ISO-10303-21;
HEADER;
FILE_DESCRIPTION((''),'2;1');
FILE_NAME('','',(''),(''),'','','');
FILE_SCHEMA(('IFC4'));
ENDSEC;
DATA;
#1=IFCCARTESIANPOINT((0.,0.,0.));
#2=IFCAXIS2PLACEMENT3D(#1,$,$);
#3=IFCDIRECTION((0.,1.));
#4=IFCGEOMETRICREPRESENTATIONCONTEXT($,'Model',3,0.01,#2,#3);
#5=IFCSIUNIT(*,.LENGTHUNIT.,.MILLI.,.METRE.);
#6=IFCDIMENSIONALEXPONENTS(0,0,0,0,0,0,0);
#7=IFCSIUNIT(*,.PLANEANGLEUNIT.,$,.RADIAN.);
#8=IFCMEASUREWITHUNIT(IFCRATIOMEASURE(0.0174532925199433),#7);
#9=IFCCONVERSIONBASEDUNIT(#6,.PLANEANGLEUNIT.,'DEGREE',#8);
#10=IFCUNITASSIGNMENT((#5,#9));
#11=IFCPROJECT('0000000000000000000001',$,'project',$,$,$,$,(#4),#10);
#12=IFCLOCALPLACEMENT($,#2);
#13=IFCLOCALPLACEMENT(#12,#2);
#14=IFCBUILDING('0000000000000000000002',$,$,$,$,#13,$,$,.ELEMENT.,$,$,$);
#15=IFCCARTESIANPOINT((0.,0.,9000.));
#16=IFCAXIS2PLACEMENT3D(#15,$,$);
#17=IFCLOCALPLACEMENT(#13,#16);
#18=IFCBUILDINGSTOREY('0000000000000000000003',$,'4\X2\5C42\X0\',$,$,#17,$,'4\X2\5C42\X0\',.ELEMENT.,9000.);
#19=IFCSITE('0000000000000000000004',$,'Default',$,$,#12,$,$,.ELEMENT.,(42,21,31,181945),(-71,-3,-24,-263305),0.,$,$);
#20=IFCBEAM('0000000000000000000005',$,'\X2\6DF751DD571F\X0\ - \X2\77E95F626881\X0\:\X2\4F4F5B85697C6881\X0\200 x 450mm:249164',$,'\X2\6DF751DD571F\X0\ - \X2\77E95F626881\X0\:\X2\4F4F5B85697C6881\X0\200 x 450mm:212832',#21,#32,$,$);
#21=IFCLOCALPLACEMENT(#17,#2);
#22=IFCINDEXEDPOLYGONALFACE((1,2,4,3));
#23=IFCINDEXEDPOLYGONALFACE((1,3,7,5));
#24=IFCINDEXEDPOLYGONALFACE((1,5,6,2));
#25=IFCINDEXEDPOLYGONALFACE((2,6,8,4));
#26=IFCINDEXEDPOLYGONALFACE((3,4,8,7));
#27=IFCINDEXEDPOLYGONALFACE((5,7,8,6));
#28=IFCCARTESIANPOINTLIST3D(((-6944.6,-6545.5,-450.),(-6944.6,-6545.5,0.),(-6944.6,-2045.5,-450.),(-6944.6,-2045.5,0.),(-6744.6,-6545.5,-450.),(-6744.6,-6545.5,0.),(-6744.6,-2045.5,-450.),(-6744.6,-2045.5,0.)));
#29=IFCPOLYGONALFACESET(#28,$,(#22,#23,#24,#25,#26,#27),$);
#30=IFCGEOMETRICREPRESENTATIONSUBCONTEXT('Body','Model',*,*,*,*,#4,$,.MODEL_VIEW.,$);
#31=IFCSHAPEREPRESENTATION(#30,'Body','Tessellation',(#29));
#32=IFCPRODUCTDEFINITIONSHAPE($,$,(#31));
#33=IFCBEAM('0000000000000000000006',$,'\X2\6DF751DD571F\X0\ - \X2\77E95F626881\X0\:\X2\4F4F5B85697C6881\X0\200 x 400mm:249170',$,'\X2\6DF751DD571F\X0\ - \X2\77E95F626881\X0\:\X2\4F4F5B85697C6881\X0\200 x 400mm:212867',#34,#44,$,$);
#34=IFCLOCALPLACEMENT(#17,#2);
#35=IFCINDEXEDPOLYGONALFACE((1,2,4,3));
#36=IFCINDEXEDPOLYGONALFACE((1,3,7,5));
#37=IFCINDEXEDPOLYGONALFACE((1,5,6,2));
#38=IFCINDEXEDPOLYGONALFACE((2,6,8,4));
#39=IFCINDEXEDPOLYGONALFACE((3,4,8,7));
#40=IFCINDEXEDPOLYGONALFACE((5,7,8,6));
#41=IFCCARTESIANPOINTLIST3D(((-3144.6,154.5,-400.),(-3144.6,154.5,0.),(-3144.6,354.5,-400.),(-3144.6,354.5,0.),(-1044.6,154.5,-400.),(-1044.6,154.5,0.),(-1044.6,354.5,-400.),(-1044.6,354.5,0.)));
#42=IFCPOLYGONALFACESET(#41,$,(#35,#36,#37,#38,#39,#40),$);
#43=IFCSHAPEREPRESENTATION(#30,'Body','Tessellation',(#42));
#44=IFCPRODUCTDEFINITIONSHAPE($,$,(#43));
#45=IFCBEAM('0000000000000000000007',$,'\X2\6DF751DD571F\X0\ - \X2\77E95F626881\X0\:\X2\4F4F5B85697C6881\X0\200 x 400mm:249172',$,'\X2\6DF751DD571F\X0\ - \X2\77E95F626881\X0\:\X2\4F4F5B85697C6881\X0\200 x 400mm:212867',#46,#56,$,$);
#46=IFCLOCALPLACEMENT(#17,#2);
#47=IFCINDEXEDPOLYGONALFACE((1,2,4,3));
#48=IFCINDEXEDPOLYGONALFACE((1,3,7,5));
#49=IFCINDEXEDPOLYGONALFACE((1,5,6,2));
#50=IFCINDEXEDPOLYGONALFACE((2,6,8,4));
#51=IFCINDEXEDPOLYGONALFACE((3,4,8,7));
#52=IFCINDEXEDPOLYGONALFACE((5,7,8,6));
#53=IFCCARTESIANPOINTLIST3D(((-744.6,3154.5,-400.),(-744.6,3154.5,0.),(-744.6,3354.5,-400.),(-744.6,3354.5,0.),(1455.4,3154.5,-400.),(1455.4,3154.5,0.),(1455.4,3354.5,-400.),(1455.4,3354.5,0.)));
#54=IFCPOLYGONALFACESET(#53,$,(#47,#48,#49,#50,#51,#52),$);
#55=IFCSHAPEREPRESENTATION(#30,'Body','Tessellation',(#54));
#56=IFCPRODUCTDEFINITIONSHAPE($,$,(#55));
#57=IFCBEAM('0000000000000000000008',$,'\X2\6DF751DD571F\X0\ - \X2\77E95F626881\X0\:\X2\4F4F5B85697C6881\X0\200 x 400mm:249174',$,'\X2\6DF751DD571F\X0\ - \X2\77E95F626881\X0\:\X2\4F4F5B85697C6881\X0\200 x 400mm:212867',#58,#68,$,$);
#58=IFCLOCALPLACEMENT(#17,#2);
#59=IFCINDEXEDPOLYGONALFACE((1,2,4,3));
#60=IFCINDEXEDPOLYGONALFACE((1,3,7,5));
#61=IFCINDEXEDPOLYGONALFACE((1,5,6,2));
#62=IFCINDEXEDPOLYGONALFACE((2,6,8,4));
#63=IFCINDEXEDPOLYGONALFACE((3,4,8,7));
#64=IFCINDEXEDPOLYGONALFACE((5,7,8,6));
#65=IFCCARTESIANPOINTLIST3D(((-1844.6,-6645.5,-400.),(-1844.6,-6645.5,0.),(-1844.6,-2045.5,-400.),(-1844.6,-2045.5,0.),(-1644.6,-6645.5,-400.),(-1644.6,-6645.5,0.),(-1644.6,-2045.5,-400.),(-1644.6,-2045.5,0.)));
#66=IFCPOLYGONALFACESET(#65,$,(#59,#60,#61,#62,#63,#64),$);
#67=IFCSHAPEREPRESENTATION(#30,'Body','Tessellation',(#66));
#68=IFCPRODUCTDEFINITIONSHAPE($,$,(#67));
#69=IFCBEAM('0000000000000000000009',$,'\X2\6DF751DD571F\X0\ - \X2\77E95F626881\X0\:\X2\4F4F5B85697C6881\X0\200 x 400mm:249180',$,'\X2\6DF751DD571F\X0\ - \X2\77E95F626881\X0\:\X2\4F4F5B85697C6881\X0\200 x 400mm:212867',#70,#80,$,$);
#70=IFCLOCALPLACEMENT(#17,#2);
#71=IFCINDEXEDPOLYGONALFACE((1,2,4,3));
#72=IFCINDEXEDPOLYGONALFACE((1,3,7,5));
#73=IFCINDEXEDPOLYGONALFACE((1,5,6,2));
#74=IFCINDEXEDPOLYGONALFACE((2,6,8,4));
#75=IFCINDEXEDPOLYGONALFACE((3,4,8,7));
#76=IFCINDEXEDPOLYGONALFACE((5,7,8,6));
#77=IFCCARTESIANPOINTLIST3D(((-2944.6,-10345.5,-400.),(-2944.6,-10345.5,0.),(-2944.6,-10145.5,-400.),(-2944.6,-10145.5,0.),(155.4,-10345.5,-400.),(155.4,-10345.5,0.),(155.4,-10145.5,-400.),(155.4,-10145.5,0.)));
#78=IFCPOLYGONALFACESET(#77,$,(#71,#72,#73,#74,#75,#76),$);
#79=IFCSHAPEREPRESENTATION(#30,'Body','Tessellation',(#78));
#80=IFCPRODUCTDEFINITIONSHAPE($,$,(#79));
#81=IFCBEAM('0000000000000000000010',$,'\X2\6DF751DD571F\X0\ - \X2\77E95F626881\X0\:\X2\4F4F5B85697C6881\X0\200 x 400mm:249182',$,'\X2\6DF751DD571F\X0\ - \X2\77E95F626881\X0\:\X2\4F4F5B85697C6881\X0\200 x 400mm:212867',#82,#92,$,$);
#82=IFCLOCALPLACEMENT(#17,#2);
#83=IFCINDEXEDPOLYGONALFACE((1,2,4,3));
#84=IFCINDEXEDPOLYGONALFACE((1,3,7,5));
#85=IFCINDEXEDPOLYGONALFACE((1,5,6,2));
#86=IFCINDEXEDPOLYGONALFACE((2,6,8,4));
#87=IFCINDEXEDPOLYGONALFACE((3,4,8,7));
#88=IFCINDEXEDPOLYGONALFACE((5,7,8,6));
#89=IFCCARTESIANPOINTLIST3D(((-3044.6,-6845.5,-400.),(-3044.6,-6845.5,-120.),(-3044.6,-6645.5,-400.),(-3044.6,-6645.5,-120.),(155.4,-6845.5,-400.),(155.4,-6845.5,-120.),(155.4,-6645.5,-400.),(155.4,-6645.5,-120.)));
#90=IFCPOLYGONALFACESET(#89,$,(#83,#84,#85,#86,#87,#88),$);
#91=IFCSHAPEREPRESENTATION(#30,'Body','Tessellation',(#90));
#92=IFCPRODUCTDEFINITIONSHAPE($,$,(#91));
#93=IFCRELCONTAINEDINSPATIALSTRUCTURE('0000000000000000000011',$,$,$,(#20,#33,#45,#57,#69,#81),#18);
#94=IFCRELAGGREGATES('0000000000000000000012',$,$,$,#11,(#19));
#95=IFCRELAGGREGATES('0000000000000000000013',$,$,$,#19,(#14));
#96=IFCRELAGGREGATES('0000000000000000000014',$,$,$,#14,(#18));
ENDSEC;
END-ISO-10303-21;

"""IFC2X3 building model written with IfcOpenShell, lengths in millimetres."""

from ifc_helpers import new_model, entity, si_unit, converted_unit, direction, frame, frame_2d, origin, origin_2d_with_axis, place, context, subcontext, project, spatial, rectangle, extrude, element, save


model = new_model("IFC2X3")

# Units and contexts
model_context = context("Model", 3, precision=0.01, world=origin(), true_north=direction((0.0, 1.0)))
body_context = subcontext(model_context, "Body", "Model", "MODEL_VIEW")
ifc_project = project(units=[si_unit("LENGTHUNIT", "METRE", prefix="MILLI"), converted_unit("PLANEANGLEUNIT", "DEGREE", entity("IfcRatioMeasure", 0.0174532925199433), si_unit("PLANEANGLEUNIT", "RADIAN"), dimensions=[0, 0, 0, 0, 0, 0, 0])], contexts=[model_context])

# Site, building, storey
site_placement = place(None, origin())
site = spatial("IfcSite", under=ifc_project, at=site_placement, Name="Default", CompositionType="ELEMENT", RefLatitude=(42, 21, 31, 181945), RefLongitude=(-71, -3, -24, -263305), RefElevation=0.0)
building_placement = place(site_placement, origin())
building = spatial("IfcBuilding", under=site, at=building_placement, CompositionType="ELEMENT")
storey_placement = place(building_placement, frame((0.0, 0.0, 9000.0)))
storey = spatial("IfcBuildingStorey", under=building, at=storey_placement, Name="4层", LongName="4层", CompositionType="ELEMENT", Elevation=9000.0)

# Beams
beam_1_placement = place(storey_placement, frame((-6844.6, -1945.5, 0.0), z_axis=(0.0, 0.0, 1.0), x_axis=(0.0, -1.0, 0.0)))
element("IfcBeam", 1, at=beam_1_placement, inside=storey, Name="混凝土 - 矩形梁:住宅楼梁200 x 450mm:249164", ObjectType="混凝土 - 矩形梁:住宅楼梁200 x 450mm:212832", context=body_context, shape_type="SweptSolid", body=[
    extrude(rectangle(XDim=450.0, YDim=200.0, at=frame_2d((0.0, 0.0), x_axis=(1.0, 0.0))), frame((100.0, 0.0, -225.0), z_axis=(1.0, 0.0, 0.0), x_axis=(0.0, 0.0, -1.0)), (0.0, 0.0, 1.0), 4500.0),
])
beam_2_placement = place(storey_placement, frame((-3244.6, 254.5, 0.0)))
element("IfcBeam", 2, at=beam_2_placement, inside=storey, Name="混凝土 - 矩形梁:住宅楼梁200 x 400mm:249170", ObjectType="混凝土 - 矩形梁:住宅楼梁200 x 400mm:212867", context=body_context, shape_type="SweptSolid", body=[
    extrude(rectangle(XDim=400.0, YDim=200.0, at=frame_2d((0.0, 0.0), x_axis=(1.0, 0.0))), frame((100.0, 0.0, -200.0), z_axis=(1.0, 0.0, 0.0), x_axis=(0.0, 0.0, -1.0)), (0.0, 0.0, 1.0), 2100.0),
])
beam_3_placement = place(storey_placement, frame((-944.6, 3254.5, 0.0)))
element("IfcBeam", 3, at=beam_3_placement, inside=storey, Name="混凝土 - 矩形梁:住宅楼梁200 x 400mm:249172", ObjectType="混凝土 - 矩形梁:住宅楼梁200 x 400mm:212867", context=body_context, shape_type="SweptSolid", body=[
    extrude(rectangle(XDim=400.0, YDim=200.0, at=frame_2d((0.0, 0.0), x_axis=(1.0, 0.0))), frame((200.0, 0.0, -200.0), z_axis=(1.0, 0.0, 0.0), x_axis=(0.0, 0.0, -1.0)), (0.0, 0.0, 1.0), 2200.0),
])
beam_4_placement = place(storey_placement, frame((-1744.6, -1945.5, 0.0), z_axis=(0.0, 0.0, 1.0), x_axis=(0.0, -1.0, 0.0)))
element("IfcBeam", 4, at=beam_4_placement, inside=storey, Name="混凝土 - 矩形梁:住宅楼梁200 x 400mm:249174", ObjectType="混凝土 - 矩形梁:住宅楼梁200 x 400mm:212867", context=body_context, shape_type="SweptSolid", body=[
    extrude(rectangle(XDim=400.0, YDim=200.0, at=origin_2d_with_axis()), frame((100.0, 0.0, -200.0), z_axis=(1.0, 0.0, 0.0), x_axis=(0.0, 0.0, -1.0)), (0.0, 0.0, 1.0), 4600.0),
])
beam_5_placement = place(storey_placement, frame((-2944.6, -10245.5, 0.0)))
element("IfcBeam", 5, at=beam_5_placement, inside=storey, Name="混凝土 - 矩形梁:住宅楼梁200 x 400mm:249180", ObjectType="混凝土 - 矩形梁:住宅楼梁200 x 400mm:212867", context=body_context, shape_type="SweptSolid", body=[
    extrude(rectangle(XDim=400.0, YDim=200.0, at=frame_2d((0.0, 0.0), x_axis=(1.0, 0.0))), frame((0.0, 0.0, -200.0), z_axis=(1.0, 0.0, 0.0), x_axis=(0.0, 0.0, -1.0)), (0.0, 0.0, 1.0), 3100.0),
])
beam_6_placement = place(storey_placement, frame((-3244.6, -6745.5, 0.0)))
element("IfcBeam", 6, at=beam_6_placement, inside=storey, Name="混凝土 - 矩形梁:住宅楼梁200 x 400mm:249182", ObjectType="混凝土 - 矩形梁:住宅楼梁200 x 400mm:212867", context=body_context, shape_type="SweptSolid", body=[
    extrude(rectangle(XDim=280.0, YDim=200.0, at=frame_2d((0.0, 0.0), x_axis=(1.0, 0.0))), frame((200.0, 0.0, -260.0), z_axis=(1.0, 0.0, 0.0), x_axis=(0.0, 0.0, -1.0)), (0.0, 0.0, 1.0), 3200.0),
])

save(model, "model.ifc")
